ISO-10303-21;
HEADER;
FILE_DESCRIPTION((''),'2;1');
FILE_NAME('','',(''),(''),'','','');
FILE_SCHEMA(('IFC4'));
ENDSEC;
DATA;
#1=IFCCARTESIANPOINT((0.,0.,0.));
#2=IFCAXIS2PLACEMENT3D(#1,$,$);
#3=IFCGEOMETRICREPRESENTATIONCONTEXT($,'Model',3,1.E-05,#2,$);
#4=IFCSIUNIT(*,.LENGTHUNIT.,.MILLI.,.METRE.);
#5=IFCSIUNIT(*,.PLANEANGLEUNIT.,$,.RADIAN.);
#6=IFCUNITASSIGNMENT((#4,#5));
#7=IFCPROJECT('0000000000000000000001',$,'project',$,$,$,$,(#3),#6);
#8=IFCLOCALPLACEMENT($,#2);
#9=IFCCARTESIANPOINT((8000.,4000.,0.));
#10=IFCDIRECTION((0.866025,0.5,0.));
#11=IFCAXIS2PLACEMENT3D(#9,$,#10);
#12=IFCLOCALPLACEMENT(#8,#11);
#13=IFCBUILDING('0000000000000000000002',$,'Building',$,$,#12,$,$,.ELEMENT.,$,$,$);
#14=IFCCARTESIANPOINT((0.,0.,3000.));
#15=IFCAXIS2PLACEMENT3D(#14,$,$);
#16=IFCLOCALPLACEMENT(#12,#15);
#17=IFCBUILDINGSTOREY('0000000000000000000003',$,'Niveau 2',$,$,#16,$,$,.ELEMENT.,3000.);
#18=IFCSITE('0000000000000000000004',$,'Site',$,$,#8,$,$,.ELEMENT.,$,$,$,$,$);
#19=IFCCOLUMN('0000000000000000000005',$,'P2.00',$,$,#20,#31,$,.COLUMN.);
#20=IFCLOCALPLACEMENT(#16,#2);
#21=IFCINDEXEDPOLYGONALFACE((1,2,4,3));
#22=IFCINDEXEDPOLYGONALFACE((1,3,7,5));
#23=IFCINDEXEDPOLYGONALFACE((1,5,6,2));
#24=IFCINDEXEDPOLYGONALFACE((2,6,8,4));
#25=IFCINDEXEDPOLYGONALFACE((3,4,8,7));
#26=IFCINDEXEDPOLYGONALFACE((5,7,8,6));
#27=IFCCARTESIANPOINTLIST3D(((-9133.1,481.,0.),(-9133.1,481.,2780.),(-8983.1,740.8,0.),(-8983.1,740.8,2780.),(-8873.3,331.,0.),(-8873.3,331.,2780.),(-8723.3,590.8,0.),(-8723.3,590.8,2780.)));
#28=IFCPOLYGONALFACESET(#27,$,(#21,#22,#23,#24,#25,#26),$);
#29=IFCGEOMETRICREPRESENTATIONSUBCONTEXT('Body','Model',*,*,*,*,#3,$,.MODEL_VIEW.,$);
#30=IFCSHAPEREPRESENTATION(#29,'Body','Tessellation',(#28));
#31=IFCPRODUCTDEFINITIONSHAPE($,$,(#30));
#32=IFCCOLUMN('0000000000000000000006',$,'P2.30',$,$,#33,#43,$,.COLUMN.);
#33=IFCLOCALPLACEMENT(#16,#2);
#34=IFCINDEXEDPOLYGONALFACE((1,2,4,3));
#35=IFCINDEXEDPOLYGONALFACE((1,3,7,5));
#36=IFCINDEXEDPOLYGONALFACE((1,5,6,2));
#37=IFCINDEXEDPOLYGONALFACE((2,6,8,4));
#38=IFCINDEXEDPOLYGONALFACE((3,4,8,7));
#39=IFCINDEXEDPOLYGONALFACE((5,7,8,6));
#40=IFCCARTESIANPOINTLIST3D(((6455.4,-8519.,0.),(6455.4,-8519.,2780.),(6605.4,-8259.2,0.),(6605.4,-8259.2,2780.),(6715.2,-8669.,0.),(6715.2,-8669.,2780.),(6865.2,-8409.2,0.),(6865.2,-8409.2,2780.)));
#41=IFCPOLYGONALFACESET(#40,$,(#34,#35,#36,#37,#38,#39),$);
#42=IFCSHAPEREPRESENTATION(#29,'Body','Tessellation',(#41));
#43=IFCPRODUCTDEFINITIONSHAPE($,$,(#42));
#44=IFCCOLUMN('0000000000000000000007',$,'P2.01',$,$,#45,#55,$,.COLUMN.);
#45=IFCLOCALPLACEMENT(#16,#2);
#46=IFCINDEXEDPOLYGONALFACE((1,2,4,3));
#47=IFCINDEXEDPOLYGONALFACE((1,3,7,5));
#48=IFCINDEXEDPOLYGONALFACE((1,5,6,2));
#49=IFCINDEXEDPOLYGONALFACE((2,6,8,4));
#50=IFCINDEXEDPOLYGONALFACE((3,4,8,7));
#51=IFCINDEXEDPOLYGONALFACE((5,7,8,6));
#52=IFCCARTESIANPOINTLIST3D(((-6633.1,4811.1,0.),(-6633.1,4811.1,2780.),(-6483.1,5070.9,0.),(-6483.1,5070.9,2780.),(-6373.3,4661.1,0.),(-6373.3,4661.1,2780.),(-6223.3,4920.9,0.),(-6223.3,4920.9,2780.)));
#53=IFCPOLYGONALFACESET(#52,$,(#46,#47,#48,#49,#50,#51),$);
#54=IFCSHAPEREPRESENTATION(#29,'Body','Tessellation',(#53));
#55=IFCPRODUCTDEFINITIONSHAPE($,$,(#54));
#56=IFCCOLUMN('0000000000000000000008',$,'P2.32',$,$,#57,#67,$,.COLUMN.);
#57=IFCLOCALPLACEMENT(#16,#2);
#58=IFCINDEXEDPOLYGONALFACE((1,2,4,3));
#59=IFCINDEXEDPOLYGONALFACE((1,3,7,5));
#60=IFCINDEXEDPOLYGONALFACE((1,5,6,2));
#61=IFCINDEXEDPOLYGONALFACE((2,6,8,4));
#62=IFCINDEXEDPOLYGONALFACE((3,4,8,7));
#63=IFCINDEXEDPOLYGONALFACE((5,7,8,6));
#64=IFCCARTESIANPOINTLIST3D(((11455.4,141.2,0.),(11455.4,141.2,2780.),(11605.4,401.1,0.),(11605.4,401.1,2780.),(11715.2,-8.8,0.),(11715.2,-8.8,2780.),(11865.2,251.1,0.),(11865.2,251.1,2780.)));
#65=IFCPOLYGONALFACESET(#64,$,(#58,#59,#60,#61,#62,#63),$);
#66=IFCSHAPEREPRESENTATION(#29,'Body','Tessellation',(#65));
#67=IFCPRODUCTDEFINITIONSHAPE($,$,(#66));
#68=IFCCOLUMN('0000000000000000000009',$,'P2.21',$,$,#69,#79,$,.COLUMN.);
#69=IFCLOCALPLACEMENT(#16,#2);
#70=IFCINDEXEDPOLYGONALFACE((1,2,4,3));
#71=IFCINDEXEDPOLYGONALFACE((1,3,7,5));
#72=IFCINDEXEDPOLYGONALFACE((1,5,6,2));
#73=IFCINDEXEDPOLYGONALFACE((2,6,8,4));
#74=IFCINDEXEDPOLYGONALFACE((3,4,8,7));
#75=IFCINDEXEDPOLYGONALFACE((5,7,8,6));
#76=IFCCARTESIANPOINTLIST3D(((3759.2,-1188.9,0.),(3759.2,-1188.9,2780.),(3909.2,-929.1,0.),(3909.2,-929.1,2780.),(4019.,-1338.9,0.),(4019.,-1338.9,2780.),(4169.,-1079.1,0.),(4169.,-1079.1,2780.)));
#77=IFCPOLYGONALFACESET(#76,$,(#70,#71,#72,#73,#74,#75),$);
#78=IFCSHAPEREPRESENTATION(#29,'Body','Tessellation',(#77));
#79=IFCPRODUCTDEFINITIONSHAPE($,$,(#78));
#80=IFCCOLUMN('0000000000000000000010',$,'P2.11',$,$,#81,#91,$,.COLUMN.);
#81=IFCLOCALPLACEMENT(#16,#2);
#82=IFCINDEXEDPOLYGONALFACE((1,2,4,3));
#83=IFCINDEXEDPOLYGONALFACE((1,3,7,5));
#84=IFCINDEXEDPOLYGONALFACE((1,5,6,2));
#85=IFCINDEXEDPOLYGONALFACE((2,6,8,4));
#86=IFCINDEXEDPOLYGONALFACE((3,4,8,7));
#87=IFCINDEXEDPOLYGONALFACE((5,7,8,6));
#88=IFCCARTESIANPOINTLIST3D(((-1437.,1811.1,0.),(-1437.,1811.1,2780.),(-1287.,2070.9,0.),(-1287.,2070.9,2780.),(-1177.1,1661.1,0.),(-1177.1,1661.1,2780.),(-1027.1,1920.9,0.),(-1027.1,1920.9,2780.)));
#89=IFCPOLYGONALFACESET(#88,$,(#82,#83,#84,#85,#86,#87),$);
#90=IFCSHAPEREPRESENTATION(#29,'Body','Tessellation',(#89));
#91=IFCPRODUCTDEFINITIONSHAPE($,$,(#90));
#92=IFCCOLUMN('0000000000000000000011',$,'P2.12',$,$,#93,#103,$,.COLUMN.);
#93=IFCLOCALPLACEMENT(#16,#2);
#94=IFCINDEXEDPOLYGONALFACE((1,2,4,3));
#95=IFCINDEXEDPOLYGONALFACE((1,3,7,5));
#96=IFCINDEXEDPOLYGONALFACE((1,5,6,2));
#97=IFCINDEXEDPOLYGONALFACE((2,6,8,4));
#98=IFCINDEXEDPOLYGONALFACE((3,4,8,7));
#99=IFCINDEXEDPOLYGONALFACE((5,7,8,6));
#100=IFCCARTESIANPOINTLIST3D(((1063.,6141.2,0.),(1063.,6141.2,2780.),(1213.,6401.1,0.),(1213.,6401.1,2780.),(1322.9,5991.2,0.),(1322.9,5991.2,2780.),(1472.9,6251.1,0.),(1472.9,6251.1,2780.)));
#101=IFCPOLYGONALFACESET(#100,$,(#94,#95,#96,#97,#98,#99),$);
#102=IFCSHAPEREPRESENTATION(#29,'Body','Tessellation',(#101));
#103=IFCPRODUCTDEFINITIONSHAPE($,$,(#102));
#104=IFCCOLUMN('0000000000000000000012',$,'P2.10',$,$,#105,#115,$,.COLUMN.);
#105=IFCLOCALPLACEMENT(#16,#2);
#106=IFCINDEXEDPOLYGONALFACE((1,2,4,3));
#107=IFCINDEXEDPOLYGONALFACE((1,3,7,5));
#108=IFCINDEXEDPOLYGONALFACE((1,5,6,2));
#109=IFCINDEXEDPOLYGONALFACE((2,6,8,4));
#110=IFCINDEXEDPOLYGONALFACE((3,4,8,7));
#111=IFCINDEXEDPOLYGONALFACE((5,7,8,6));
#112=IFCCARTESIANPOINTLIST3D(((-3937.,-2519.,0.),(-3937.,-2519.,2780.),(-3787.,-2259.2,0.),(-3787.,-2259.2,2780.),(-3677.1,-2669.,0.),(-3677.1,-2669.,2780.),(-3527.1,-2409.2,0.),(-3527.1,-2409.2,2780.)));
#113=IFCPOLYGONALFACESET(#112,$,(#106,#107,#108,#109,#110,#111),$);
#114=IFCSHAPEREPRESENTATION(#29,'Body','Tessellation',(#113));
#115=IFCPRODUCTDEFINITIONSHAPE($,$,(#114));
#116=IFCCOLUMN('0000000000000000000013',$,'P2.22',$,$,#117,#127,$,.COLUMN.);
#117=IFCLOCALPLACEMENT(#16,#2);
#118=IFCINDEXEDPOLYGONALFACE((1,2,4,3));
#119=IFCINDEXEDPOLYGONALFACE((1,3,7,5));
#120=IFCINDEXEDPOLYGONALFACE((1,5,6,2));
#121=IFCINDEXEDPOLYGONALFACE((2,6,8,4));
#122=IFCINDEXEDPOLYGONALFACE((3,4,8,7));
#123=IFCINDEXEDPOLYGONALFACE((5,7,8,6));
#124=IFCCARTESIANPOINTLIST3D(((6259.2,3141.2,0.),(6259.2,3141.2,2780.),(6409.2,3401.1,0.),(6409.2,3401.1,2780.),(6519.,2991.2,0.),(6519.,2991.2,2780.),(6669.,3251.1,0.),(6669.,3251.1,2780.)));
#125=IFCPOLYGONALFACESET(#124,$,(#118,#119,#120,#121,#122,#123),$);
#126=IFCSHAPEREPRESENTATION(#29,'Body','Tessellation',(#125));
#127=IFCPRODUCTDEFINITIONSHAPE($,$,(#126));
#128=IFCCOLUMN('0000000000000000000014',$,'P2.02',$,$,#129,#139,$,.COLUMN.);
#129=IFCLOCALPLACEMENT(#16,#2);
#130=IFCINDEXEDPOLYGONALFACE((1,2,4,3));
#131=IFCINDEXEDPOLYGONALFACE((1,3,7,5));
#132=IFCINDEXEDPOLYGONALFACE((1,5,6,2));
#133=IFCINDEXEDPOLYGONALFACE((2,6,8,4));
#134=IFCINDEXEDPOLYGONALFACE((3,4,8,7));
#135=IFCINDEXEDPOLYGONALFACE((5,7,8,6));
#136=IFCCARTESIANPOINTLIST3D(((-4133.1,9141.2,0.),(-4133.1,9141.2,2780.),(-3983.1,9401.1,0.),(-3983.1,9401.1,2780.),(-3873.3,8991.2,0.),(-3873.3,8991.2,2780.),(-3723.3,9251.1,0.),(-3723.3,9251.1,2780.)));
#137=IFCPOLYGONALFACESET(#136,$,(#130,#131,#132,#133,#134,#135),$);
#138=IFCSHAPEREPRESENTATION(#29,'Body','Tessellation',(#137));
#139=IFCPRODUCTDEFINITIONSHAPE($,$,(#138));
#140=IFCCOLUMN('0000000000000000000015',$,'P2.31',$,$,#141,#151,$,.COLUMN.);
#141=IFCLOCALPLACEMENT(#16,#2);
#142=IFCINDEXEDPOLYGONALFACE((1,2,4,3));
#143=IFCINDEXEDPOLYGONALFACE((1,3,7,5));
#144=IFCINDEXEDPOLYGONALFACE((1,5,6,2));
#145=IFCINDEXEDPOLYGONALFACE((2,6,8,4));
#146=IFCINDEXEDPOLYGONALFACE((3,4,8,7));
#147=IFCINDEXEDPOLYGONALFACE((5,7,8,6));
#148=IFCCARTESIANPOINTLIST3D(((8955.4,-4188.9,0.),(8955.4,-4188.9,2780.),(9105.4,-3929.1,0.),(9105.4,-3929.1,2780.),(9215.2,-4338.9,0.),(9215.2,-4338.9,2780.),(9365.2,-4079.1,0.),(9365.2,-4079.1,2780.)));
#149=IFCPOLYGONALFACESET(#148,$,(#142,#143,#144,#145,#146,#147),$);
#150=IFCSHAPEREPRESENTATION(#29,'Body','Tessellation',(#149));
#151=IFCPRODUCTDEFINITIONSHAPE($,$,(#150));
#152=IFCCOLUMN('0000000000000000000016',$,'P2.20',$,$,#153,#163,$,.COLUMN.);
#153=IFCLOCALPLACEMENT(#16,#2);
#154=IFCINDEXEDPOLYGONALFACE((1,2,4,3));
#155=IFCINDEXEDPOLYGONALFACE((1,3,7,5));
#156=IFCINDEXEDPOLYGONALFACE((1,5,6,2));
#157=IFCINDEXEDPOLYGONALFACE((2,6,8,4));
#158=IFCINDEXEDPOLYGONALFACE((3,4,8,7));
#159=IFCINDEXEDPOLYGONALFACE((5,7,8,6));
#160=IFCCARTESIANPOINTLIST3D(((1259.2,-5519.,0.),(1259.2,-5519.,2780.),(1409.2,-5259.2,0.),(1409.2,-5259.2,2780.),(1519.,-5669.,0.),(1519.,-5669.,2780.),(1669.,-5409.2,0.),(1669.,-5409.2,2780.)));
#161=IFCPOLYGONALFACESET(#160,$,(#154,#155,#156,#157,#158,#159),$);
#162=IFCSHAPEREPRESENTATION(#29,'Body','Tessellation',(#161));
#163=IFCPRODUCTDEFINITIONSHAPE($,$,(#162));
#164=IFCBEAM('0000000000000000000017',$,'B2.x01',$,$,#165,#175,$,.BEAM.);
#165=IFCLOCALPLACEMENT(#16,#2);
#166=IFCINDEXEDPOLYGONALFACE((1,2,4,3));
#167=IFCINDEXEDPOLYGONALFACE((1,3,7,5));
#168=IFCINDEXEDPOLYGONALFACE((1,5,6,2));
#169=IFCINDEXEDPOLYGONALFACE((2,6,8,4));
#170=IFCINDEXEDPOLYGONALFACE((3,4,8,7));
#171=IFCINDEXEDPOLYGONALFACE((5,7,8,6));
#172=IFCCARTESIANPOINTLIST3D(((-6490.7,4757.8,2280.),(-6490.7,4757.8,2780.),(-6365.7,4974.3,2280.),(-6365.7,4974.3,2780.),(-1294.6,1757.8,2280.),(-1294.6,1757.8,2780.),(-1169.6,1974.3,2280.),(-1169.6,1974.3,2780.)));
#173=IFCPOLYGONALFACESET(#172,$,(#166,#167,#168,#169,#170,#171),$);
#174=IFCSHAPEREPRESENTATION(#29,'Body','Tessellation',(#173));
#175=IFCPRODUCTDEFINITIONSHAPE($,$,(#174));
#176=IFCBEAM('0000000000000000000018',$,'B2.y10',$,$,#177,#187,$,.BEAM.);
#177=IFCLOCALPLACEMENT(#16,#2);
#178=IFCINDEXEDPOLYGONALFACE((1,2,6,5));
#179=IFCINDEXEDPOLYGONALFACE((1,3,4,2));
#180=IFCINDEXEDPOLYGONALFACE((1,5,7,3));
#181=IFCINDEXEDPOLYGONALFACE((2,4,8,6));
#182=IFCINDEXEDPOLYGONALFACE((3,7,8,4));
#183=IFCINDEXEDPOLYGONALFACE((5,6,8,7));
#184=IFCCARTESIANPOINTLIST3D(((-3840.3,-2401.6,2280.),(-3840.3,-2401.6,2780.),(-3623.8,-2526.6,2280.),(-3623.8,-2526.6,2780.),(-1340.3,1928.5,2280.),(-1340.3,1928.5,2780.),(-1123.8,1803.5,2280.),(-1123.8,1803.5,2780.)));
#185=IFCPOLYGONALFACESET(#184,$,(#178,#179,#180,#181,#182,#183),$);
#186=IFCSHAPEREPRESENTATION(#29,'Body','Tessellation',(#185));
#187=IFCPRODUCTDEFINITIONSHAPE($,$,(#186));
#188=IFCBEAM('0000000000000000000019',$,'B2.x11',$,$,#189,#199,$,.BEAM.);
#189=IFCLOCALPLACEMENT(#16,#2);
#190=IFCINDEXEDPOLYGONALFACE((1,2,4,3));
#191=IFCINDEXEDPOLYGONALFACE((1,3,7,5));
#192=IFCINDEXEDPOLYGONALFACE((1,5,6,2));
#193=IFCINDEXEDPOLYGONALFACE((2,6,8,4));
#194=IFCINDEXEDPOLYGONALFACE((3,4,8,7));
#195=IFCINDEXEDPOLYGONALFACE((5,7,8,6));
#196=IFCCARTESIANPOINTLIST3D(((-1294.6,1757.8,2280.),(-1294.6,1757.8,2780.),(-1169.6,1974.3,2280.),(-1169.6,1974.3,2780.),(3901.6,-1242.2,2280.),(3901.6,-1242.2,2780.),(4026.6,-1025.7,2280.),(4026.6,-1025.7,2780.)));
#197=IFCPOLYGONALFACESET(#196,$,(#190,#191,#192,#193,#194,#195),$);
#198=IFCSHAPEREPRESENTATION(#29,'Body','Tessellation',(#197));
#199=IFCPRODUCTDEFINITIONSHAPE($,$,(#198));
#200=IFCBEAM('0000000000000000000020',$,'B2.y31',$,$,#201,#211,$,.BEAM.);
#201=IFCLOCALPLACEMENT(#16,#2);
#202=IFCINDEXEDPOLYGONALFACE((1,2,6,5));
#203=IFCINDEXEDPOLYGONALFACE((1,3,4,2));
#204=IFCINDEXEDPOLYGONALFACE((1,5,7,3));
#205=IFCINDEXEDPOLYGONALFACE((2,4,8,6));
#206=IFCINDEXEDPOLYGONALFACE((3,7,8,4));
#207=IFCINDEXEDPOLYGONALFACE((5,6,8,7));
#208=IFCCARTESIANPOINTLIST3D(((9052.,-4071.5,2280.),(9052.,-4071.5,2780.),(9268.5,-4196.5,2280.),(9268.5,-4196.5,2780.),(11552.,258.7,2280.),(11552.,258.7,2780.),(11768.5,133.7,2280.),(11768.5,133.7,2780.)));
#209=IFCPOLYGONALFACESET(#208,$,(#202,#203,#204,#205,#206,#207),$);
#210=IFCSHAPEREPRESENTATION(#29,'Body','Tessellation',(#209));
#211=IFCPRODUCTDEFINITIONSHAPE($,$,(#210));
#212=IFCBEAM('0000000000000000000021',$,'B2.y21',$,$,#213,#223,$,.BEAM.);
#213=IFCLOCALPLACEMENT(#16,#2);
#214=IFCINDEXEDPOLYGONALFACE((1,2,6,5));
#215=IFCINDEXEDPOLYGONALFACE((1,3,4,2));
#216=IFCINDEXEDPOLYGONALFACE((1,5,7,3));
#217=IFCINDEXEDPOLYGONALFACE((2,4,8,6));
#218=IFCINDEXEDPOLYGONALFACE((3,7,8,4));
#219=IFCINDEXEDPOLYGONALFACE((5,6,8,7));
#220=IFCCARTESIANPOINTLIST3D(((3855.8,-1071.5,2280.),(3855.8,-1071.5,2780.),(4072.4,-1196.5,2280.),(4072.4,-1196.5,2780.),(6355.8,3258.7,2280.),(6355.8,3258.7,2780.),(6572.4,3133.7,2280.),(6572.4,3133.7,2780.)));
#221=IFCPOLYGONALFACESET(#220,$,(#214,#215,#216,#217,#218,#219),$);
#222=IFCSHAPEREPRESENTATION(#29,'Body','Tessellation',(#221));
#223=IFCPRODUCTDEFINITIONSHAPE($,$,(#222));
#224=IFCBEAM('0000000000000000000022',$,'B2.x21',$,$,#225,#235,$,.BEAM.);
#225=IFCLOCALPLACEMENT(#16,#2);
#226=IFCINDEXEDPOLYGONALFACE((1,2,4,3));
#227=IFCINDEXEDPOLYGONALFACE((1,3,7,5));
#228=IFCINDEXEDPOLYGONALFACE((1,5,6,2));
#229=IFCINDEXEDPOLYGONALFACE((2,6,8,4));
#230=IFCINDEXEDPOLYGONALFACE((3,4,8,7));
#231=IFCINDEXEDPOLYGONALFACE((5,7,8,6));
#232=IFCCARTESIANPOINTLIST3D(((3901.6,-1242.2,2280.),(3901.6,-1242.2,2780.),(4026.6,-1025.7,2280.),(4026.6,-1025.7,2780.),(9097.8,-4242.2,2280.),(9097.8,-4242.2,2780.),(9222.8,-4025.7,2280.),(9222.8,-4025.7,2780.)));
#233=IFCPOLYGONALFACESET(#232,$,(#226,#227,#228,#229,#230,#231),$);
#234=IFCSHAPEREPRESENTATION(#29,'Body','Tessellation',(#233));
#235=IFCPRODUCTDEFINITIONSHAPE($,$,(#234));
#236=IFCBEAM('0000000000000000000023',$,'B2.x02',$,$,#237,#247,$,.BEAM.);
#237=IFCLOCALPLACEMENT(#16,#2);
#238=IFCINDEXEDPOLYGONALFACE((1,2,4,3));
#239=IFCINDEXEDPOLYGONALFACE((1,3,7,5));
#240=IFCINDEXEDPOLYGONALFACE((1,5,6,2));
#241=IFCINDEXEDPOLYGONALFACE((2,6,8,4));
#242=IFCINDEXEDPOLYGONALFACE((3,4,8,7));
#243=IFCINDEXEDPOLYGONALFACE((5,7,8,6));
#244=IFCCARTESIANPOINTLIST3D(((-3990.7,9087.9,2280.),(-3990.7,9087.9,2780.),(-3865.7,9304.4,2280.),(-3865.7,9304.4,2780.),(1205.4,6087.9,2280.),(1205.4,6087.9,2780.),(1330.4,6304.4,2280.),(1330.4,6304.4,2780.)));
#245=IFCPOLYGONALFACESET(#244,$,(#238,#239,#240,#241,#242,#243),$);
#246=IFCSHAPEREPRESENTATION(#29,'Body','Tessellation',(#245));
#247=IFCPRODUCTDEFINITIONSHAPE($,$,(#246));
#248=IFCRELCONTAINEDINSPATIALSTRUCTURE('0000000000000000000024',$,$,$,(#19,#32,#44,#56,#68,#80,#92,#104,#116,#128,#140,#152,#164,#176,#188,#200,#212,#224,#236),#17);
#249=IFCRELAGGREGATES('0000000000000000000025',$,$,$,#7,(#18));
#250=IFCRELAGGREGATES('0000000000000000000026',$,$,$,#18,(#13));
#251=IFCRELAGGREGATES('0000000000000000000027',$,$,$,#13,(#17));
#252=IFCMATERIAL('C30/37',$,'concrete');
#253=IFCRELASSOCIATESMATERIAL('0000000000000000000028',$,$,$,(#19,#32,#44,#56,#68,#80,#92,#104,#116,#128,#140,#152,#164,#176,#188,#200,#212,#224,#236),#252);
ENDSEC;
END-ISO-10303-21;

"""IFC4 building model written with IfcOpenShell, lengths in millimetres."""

from ifc_helpers import new_model, si_unit, frame, origin, place, context, subcontext, project, spatial, rectangle, extrude, material, element, save


model = new_model("IFC4")

# Units and contexts
model_context = context("Model", 3, precision=1e-05, world=origin())
body_context = subcontext(model_context, "Body", "Model", "MODEL_VIEW")
ifc_project = project(units=[si_unit("LENGTHUNIT", "METRE", prefix="MILLI"), si_unit("PLANEANGLEUNIT", "RADIAN")], contexts=[model_context])

# Site, building, storey
site_placement = place(None, origin())
site = spatial("IfcSite", under=ifc_project, at=site_placement, Name="Site", CompositionType="ELEMENT")
building_placement = place(site_placement, frame((8000.0, 4000.0, 0.0), x_axis=(0.866025, 0.5, 0.0)))
building = spatial("IfcBuilding", under=site, at=building_placement, Name="Building", CompositionType="ELEMENT")
storey_placement = place(building_placement, frame((0.0, 0.0, 3000.0)))
storey = spatial("IfcBuildingStorey", under=building, at=storey_placement, Name="Niveau 2", CompositionType="ELEMENT", Elevation=3000.0)

# Columns
ifc_material = material(Name="C30/37", Category="concrete")
for number, where, z_axis, x_axis, name in (
    (1, (-8928.2, 535.9, 0.0), (0.0, 0.0, 1.0), (0.866025, -0.5, 0.0), "P2.00"),
    (2, (6660.3, -8464.1, 0.0), (0.0, 0.0, 1.0), (0.866025, -0.5, 0.0), "P2.30"),
    (3, (-6428.2, 4866.0, 0.0), (0.0, 0.0, 1.0), (0.866025, -0.5, 0.0), "P2.01"),
    (4, (11660.3, 196.2, 0.0), (0.0, 0.0, 1.0), (0.866025, -0.5, 0.0), "P2.32"),
    (5, (3964.1, -1134.0, 0.0), (0.0, 0.0, 1.0), (0.866025, -0.5, 0.0), "P2.21"),
    (6, (-1232.1, 1866.0, 0.0), (0.0, 0.0, 1.0), (0.866025, -0.5, 0.0), "P2.11"),
    (7, (1267.9, 6196.2, 0.0), (0.0, 0.0, 1.0), (0.866025, -0.5, 0.0), "P2.12"),
    (8, (-3732.1, -2464.1, 0.0), (0.0, 0.0, 1.0), (0.866025, -0.5, 0.0), "P2.10"),
    (9, (6464.1, 3196.2, 0.0), (0.0, 0.0, 1.0), (0.866025, -0.5, 0.0), "P2.22"),
    (10, (-3928.2, 9196.2, 0.0), (0.0, 0.0, 1.0), (0.866025, -0.5, 0.0), "P2.02"),
    (11, (9160.3, -4134.0, 0.0), (0.0, 0.0, 1.0), (0.866025, -0.5, 0.0), "P2.31"),
    (12, (1464.1, -5464.1, 0.0), (0.0, 0.0, 1.0), (0.866025, -0.5, 0.0), "P2.20"),
):
    element("IfcColumn", number, at=place(storey_placement, frame(where, z_axis=z_axis, x_axis=x_axis)), inside=storey, material=ifc_material, Name=name, PredefinedType="COLUMN", context=body_context, shape_type="SweptSolid", body=[
        extrude(rectangle(XDim=300.0, YDim=300.0), origin(), (0.0, 0.0, 1.0), 2780.0),
    ])

# Beams
beam_1_placement = place(storey_placement, frame((-6428.2, 4866.0, 2530.0), z_axis=(0.866025, -0.5, 0.0), x_axis=(0.5, 0.866025, 0.0)))
element("IfcBeam", 13, at=beam_1_placement, inside=storey, material=ifc_material, Name="B2.x01", PredefinedType="BEAM", context=body_context, shape_type="SweptSolid", body=[
    extrude(rectangle(XDim=250.0, YDim=500.0), origin(), (0.0, 0.0, 1.0), 6000.0),
])
beam_2_placement = place(storey_placement, frame((-3732.1, -2464.1, 2530.0), z_axis=(0.5, 0.866025, 0.0), x_axis=(-0.866025, 0.5, 0.0)))
element("IfcBeam", 14, at=beam_2_placement, inside=storey, material=ifc_material, Name="B2.y10", PredefinedType="BEAM", context=body_context, shape_type="SweptSolid", body=[
    extrude(rectangle(XDim=250.0, YDim=500.0), origin(), (0.0, 0.0, 1.0), 5000.0),
])
beam_3_placement = place(storey_placement, frame((-1232.1, 1866.0, 2530.0), z_axis=(0.866025, -0.5, 0.0), x_axis=(0.5, 0.866025, 0.0)))
element("IfcBeam", 15, at=beam_3_placement, inside=storey, material=ifc_material, Name="B2.x11", PredefinedType="BEAM", context=body_context, shape_type="SweptSolid", body=[
    extrude(rectangle(XDim=250.0, YDim=500.0), origin(), (0.0, 0.0, 1.0), 6000.0),
])
for number, where, z_axis, x_axis, name in (
    (16, (9160.3, -4134.0, 2530.0), (0.5, 0.866025, 0.0), (-0.866025, 0.5, 0.0), "B2.y31"),
    (17, (3964.1, -1134.0, 2530.0), (0.5, 0.866025, 0.0), (-0.866025, 0.5, 0.0), "B2.y21"),
):
    element("IfcBeam", number, at=place(storey_placement, frame(where, z_axis=z_axis, x_axis=x_axis)), inside=storey, material=ifc_material, Name=name, PredefinedType="BEAM", context=body_context, shape_type="SweptSolid", body=[
        extrude(rectangle(XDim=250.0, YDim=500.0), origin(), (0.0, 0.0, 1.0), 5000.0),
    ])
for number, where, z_axis, x_axis, name in (
    (18, (3964.1, -1134.0, 2530.0), (0.866025, -0.5, 0.0), (0.5, 0.866025, 0.0), "B2.x21"),
    (19, (-3928.2, 9196.2, 2530.0), (0.866025, -0.5, 0.0), (0.5, 0.866025, 0.0), "B2.x02"),
):
    element("IfcBeam", number, at=place(storey_placement, frame(where, z_axis=z_axis, x_axis=x_axis)), inside=storey, material=ifc_material, Name=name, PredefinedType="BEAM", context=body_context, shape_type="SweptSolid", body=[
        extrude(rectangle(XDim=250.0, YDim=500.0), origin(), (0.0, 0.0, 1.0), 6000.0),
    ])

save(model, "model.ifc")
